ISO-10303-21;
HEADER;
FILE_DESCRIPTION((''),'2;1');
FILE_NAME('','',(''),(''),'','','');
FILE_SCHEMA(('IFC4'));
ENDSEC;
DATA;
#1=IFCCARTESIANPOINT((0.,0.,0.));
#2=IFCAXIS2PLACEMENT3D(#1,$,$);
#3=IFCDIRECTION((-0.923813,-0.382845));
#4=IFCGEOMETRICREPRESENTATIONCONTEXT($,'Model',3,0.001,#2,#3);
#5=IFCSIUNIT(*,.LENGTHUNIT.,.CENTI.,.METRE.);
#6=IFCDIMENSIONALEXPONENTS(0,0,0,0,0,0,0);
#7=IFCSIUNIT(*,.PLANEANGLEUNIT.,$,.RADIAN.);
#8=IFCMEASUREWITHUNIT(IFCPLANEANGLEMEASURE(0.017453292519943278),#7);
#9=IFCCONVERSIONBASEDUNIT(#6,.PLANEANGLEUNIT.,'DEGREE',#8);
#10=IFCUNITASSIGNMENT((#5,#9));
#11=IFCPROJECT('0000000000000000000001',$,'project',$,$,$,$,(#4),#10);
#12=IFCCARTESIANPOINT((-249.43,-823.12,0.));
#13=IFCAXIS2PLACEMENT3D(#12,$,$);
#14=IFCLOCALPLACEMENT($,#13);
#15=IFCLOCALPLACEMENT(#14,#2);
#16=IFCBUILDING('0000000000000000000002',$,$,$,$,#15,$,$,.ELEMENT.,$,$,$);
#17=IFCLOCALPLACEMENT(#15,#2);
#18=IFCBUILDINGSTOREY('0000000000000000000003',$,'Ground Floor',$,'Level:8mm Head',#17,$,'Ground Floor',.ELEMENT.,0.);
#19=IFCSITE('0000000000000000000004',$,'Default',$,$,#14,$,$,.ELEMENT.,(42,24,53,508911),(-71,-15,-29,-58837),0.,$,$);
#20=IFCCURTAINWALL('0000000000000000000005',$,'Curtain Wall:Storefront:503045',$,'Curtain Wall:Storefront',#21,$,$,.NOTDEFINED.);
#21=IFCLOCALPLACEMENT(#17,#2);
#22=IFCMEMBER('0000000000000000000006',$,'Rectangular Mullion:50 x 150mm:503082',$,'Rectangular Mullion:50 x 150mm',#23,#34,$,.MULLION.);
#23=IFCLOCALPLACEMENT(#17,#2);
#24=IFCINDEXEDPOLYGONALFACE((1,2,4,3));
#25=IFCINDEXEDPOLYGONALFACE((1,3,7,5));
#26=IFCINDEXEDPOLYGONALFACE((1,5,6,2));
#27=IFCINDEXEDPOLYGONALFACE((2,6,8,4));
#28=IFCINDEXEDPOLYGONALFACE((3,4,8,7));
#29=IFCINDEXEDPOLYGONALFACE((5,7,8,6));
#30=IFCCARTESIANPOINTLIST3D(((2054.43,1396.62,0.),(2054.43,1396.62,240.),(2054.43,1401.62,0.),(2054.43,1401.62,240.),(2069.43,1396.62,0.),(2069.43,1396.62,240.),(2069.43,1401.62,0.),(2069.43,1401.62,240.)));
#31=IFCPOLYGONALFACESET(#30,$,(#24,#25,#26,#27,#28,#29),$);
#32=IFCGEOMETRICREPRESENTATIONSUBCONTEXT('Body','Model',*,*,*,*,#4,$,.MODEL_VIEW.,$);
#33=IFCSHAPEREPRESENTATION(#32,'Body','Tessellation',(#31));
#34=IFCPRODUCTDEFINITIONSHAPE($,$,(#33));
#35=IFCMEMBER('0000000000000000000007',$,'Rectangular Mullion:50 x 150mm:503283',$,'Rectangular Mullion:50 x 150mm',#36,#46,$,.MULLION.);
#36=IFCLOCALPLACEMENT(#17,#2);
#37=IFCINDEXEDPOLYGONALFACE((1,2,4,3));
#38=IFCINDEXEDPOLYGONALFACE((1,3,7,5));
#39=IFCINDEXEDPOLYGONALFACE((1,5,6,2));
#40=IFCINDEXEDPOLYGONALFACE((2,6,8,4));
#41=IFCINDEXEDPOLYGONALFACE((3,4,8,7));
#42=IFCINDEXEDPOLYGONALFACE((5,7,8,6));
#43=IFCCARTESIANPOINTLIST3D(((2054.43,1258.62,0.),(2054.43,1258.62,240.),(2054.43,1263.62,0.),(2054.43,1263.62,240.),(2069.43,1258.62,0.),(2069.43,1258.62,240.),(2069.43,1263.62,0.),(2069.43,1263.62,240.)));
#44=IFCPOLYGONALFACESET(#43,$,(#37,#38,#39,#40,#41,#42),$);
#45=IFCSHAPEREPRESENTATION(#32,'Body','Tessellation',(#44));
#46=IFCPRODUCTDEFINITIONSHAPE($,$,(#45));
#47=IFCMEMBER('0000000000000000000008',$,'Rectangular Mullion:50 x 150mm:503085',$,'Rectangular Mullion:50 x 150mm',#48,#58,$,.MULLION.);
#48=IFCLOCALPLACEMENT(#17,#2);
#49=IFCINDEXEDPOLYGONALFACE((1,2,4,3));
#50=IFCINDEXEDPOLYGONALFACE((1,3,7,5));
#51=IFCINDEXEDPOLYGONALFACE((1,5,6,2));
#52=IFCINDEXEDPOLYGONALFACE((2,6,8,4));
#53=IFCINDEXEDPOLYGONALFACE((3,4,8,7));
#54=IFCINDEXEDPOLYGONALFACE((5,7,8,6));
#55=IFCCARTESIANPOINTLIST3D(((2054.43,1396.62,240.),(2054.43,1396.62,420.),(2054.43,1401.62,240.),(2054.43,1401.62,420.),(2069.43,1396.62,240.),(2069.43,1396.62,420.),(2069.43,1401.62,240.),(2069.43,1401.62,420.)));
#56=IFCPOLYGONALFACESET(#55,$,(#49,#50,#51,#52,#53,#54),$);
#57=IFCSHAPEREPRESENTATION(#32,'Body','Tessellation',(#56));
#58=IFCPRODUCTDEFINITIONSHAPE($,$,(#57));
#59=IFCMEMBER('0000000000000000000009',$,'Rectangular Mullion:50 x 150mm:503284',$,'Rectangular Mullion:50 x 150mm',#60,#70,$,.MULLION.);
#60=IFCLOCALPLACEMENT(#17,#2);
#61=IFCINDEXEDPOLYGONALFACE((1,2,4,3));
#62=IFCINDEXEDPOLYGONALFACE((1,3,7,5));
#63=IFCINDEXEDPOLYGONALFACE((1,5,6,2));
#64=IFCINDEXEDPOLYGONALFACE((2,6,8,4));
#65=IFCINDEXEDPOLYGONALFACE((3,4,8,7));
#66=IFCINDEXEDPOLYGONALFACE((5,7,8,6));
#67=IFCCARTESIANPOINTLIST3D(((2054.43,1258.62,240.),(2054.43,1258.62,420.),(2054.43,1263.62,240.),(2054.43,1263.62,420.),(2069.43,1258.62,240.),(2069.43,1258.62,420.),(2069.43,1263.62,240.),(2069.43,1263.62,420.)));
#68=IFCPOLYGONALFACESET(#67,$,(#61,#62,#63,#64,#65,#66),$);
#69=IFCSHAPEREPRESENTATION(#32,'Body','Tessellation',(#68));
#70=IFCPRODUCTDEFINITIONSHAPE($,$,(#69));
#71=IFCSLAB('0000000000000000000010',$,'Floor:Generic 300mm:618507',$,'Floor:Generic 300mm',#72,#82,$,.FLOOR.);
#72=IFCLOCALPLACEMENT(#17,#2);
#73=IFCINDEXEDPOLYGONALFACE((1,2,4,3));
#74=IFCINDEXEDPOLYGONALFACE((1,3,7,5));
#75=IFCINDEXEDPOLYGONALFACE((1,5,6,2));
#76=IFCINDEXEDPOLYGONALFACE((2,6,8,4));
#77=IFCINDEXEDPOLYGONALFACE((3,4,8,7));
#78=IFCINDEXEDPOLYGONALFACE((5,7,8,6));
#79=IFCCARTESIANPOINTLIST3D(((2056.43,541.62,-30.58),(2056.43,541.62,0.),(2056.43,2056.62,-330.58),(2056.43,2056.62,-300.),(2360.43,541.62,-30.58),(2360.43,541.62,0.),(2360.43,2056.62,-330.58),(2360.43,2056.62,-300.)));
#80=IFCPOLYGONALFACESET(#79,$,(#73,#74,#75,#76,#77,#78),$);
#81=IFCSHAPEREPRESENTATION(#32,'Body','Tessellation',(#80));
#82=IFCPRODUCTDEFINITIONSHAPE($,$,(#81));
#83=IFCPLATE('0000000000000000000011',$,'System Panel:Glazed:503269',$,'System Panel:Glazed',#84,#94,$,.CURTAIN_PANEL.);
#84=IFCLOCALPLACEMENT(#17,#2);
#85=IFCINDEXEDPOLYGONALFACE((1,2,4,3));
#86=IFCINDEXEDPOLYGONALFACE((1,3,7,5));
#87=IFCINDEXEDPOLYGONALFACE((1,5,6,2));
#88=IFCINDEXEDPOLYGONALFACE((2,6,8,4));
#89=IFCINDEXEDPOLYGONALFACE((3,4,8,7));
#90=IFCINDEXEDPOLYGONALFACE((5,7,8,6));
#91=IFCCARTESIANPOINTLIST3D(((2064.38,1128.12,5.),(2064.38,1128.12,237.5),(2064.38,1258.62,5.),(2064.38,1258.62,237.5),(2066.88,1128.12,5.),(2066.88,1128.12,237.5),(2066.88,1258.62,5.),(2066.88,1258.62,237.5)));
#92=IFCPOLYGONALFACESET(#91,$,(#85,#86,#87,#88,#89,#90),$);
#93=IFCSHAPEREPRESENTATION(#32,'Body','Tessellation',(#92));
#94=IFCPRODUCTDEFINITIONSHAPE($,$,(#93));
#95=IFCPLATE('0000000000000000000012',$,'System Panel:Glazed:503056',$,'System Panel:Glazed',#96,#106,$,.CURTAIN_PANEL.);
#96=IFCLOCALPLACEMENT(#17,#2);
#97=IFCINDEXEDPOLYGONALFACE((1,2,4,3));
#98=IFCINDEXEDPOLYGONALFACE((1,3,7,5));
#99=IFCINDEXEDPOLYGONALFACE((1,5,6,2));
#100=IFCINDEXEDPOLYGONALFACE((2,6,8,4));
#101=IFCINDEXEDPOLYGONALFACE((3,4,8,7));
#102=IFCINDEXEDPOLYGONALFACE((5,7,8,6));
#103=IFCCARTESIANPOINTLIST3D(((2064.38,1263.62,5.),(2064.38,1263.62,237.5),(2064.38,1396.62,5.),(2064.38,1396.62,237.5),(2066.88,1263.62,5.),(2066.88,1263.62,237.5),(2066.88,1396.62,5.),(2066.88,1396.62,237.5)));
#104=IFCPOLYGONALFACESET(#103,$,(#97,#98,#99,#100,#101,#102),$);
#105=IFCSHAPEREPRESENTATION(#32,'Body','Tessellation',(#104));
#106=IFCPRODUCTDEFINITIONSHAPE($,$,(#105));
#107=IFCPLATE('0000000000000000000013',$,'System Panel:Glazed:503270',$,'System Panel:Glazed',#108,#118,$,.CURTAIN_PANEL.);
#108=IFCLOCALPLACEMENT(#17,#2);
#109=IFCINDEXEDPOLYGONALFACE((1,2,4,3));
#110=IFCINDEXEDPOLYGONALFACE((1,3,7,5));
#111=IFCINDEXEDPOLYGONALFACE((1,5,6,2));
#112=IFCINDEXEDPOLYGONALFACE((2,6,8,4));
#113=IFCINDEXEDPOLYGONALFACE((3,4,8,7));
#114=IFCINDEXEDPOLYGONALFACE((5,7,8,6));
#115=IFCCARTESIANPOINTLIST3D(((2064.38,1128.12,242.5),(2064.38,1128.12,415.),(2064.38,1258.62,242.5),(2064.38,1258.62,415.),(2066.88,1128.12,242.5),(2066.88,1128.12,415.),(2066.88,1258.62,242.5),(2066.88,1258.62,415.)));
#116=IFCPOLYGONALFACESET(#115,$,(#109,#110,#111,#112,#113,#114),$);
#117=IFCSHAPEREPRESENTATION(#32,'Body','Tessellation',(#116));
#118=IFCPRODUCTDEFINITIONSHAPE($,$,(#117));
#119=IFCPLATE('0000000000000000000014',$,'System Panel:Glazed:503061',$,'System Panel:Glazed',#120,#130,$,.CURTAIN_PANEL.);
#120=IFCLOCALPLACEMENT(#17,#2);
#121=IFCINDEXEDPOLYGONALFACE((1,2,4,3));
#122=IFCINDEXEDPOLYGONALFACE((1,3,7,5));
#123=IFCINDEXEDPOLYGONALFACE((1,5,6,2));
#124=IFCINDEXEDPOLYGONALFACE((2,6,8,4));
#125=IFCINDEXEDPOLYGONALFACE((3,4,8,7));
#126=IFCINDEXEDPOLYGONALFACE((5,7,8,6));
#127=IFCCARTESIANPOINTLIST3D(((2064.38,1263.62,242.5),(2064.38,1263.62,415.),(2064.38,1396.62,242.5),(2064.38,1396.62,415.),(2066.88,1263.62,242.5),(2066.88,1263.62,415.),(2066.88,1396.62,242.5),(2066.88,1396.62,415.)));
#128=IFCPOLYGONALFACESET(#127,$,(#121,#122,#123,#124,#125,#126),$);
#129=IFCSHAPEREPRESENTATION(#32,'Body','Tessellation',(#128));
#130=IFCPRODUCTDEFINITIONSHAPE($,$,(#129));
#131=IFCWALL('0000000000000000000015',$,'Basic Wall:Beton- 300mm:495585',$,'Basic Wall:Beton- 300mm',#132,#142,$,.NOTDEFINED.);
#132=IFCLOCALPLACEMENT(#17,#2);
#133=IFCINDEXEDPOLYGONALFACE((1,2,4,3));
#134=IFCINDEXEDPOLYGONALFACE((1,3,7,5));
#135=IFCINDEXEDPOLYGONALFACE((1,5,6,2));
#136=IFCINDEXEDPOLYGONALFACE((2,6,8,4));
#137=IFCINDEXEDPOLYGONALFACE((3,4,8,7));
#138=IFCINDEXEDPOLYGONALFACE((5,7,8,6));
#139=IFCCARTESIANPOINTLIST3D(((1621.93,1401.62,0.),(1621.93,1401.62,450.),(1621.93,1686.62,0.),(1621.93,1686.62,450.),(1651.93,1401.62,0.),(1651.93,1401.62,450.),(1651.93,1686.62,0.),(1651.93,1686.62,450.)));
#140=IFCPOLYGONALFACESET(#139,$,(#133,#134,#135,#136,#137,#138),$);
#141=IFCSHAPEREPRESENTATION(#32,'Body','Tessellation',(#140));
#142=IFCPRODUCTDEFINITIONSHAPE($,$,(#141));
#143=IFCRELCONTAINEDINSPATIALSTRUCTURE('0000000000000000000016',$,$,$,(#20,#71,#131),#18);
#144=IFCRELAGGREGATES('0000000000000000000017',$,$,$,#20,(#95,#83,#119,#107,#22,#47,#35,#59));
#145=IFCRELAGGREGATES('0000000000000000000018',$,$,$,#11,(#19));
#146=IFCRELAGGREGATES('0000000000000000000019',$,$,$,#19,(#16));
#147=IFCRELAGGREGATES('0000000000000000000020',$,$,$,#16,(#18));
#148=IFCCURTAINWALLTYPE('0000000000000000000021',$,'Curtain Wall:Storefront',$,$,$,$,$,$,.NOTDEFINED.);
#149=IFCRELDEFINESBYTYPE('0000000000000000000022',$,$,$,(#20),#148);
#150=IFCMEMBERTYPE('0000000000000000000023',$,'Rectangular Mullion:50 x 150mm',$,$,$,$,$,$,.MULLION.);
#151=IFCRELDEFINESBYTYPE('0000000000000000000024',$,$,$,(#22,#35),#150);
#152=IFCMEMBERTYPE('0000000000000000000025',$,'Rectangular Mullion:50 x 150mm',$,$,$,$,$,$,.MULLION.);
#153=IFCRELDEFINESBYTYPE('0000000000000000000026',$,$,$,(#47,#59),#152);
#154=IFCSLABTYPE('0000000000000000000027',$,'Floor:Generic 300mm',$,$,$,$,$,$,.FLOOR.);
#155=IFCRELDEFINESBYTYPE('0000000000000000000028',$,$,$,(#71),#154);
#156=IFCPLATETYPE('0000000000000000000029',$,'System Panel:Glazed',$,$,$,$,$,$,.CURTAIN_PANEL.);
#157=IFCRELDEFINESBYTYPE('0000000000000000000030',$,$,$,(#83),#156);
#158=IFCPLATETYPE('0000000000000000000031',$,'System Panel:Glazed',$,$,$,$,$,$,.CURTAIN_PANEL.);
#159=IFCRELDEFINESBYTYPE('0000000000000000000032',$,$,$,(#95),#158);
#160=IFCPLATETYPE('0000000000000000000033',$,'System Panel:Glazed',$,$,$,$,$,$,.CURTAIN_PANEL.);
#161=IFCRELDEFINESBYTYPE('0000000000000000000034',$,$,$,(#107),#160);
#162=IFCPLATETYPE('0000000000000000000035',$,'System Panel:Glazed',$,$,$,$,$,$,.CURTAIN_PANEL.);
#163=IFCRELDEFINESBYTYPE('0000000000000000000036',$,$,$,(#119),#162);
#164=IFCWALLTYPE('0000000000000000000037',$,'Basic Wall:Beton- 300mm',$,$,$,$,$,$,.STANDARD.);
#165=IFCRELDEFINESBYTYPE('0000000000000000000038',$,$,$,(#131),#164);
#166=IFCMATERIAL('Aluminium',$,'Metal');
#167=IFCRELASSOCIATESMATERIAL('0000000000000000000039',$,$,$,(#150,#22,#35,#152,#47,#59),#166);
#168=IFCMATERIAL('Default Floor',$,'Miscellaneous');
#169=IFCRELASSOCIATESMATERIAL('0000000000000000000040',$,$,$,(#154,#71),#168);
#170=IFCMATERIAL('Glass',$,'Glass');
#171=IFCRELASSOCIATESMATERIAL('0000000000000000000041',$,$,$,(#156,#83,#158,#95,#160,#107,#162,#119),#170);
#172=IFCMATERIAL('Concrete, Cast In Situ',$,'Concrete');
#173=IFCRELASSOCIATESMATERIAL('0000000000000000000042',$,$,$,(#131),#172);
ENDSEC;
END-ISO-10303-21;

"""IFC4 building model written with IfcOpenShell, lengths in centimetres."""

from ifc_helpers import new_model, entity, si_unit, converted_unit, direction, frame, frame_2d, origin, place, context, subcontext, project, spatial, indexed_curve, rectangle, outline, extrude, source, transform, mapped, material, type_object, type_shapes, element, aggregate, save


model = new_model("IFC4")

# Units and contexts
model_context = context("Model", 3, precision=0.001, world=origin(), true_north=direction((-0.923813, -0.382845)))
body_context = subcontext(model_context, "Body", "Model", "MODEL_VIEW")
ifc_project = project(units=[si_unit("LENGTHUNIT", "METRE", prefix="CENTI"), converted_unit("PLANEANGLEUNIT", "DEGREE", entity("IfcPlaneAngleMeasure", 0.017453292519943278), si_unit("PLANEANGLEUNIT", "RADIAN"), dimensions=[0, 0, 0, 0, 0, 0, 0])], contexts=[model_context])

# Site, building, storey
site_placement = place(None, frame((-249.43, -823.12, 0.0)))
site = spatial("IfcSite", under=ifc_project, at=site_placement, Name="Default", CompositionType="ELEMENT", RefLatitude=(42, 24, 53, 508911), RefLongitude=(-71, -15, -29, -58837), RefElevation=0.0)
building_placement = place(site_placement, origin())
building = spatial("IfcBuilding", under=site, at=building_placement, CompositionType="ELEMENT")
storey_placement = place(building_placement, origin())
storey = spatial("IfcBuildingStorey", under=building, at=storey_placement, Name="Ground Floor", ObjectType="Level:8mm Head", LongName="Ground Floor", CompositionType="ELEMENT", Elevation=0.0)

# Curtain wall, members
curtain_wall_type = type_object("IfcCurtainWallType", Name="Curtain Wall:Storefront", PredefinedType="NOTDEFINED")
curtain_wall_placement = place(storey_placement, origin())
curtain_wall = element("IfcCurtainWall", 1, at=curtain_wall_placement, inside=storey, type_object=curtain_wall_type, Name="Curtain Wall:Storefront:503045", ObjectType="Curtain Wall:Storefront", PredefinedType="NOTDEFINED")
ifc_material_1 = material(Name="Aluminium", Category="Metal")
member_type_1 = type_object("IfcMemberType", Name="Rectangular Mullion:50 x 150mm", PredefinedType="MULLION", material=ifc_material_1)
shared_shape_1 = source(origin(), body_context, "Body", "SweptSolid", [
    extrude(outline(indexed_curve([(-2.5, -7.5), (2.5, -7.5), (2.5, 7.5), (-2.5, 7.5), (-2.5, -7.5)], self_intersect=False)), frame((0.0, 0.0, -240.0), z_axis=(0.0, 0.0, 1.0), x_axis=(-1.0, 0.0, 0.0)), (0.0, 0.0, 1.0), 240.0),
])
type_shapes(member_type_1, [shared_shape_1])
member_1_placement = place(curtain_wall_placement, frame((2061.93, 1399.12, 0.0), z_axis=(0.0, 0.0, -1.0), x_axis=(0.0, -1.0, 0.0)))
member_1 = element("IfcMember", 2, at=member_1_placement, type_object=member_type_1, material=ifc_material_1, Name="Rectangular Mullion:50 x 150mm:503082", ObjectType="Rectangular Mullion:50 x 150mm", PredefinedType="MULLION", context=body_context, shape_type="MappedRepresentation", body=[
    mapped(shared_shape_1, transform((0.0, 0.0, 0.0), scale=1.0)),
])
member_2_placement = place(curtain_wall_placement, frame((2061.93, 1261.12, 0.0), z_axis=(0.0, 0.0, -1.0), x_axis=(0.0, -1.0, 0.0)))
member_2 = element("IfcMember", 3, at=member_2_placement, type_object=member_type_1, material=ifc_material_1, Name="Rectangular Mullion:50 x 150mm:503283", ObjectType="Rectangular Mullion:50 x 150mm", PredefinedType="MULLION", context=body_context, shape_type="MappedRepresentation", body=[
    mapped(shared_shape_1, transform((0.0, 0.0, 0.0), scale=1.0)),
])
member_type_2 = type_object("IfcMemberType", Name="Rectangular Mullion:50 x 150mm", PredefinedType="MULLION", material=ifc_material_1)
shared_shape_2 = source(origin(), body_context, "Body", "SweptSolid", [
    extrude(outline(indexed_curve([(-2.5, -7.5), (2.5, -7.5), (2.5, 7.5), (-2.5, 7.5), (-2.5, -7.5)], self_intersect=False)), frame((0.0, 0.0, -180.0), z_axis=(0.0, 0.0, 1.0), x_axis=(-1.0, 0.0, 0.0)), (0.0, 0.0, 1.0), 180.0),
])
type_shapes(member_type_2, [shared_shape_2])
member_3_placement = place(curtain_wall_placement, frame((2061.93, 1399.12, 240.0), z_axis=(0.0, 0.0, -1.0), x_axis=(0.0, -1.0, 0.0)))
member_3 = element("IfcMember", 4, at=member_3_placement, type_object=member_type_2, material=ifc_material_1, Name="Rectangular Mullion:50 x 150mm:503085", ObjectType="Rectangular Mullion:50 x 150mm", PredefinedType="MULLION", context=body_context, shape_type="MappedRepresentation", body=[
    mapped(shared_shape_2, transform((0.0, 0.0, 0.0), scale=1.0)),
])
member_4_placement = place(curtain_wall_placement, frame((2061.93, 1261.12, 240.0), z_axis=(0.0, 0.0, -1.0), x_axis=(0.0, -1.0, 0.0)))
member_4 = element("IfcMember", 5, at=member_4_placement, type_object=member_type_2, material=ifc_material_1, Name="Rectangular Mullion:50 x 150mm:503284", ObjectType="Rectangular Mullion:50 x 150mm", PredefinedType="MULLION", context=body_context, shape_type="MappedRepresentation", body=[
    mapped(shared_shape_2, transform((0.0, 0.0, 0.0), scale=1.0)),
])

# Slab
ifc_material_2 = material(Name="Default Floor", Category="Miscellaneous")
slab_type = type_object("IfcSlabType", Name="Floor:Generic 300mm", PredefinedType="FLOOR", material=ifc_material_2)
slab_placement = place(storey_placement, frame((2056.43, 541.62, -330.58)))
element("IfcSlab", 6, at=slab_placement, inside=storey, type_object=slab_type, material=ifc_material_2, Name="Floor:Generic 300mm:618507", ObjectType="Floor:Generic 300mm", PredefinedType="FLOOR", context=body_context, shape_type="SweptSolid", body=[
    extrude(rectangle(XDim=1544.42, YDim=304.0, at=frame_2d((-7.0, -772.21), x_axis=(0.0, 1.0))), frame((159.0, 1515.0, 30.58), z_axis=(0.0, 0.194248, 0.980952), x_axis=(1.0, 0.0, 0.0)), (0.0, 0.194248, -0.980952), 30.58),
])

# Plates
ifc_material_3 = material(Name="Glass", Category="Glass")
plate_type_1 = type_object("IfcPlateType", Name="System Panel:Glazed", PredefinedType="CURTAIN_PANEL", material=ifc_material_3)
shared_shape_3 = source(origin(), body_context, "Body", "SweptSolid", [
    extrude(outline(indexed_curve([(-1.25, -65.25), (1.25, -65.25), (1.25, 65.25), (-1.25, 65.25), (-1.25, -65.25)], self_intersect=False)), frame((65.25, 1.25, 0.0), z_axis=(0.0, 0.0, 1.0), x_axis=(0.0, 1.0, 0.0)), (0.0, 0.0, 1.0), 232.5),
])
type_shapes(plate_type_1, [shared_shape_3])
plate_1_placement = place(curtain_wall_placement, frame((2064.38, 1258.62, 5.0), z_axis=(0.0, 0.0, 1.0), x_axis=(0.0, -1.0, 0.0)))
plate_1 = element("IfcPlate", 7, at=plate_1_placement, type_object=plate_type_1, material=ifc_material_3, Name="System Panel:Glazed:503269", ObjectType="System Panel:Glazed", PredefinedType="CURTAIN_PANEL", context=body_context, shape_type="MappedRepresentation", body=[
    mapped(shared_shape_3, transform((0.0, 0.0, 0.0), scale=1.0)),
])
plate_type_2 = type_object("IfcPlateType", Name="System Panel:Glazed", PredefinedType="CURTAIN_PANEL", material=ifc_material_3)
shared_shape_4 = source(origin(), body_context, "Body", "SweptSolid", [
    extrude(outline(indexed_curve([(-1.25, -66.5), (1.25, -66.5), (1.25, 66.5), (-1.25, 66.5), (-1.25, -66.5)], self_intersect=False)), frame((66.5, 1.25, 0.0), z_axis=(0.0, 0.0, 1.0), x_axis=(0.0, 1.0, 0.0)), (0.0, 0.0, 1.0), 232.5),
])
type_shapes(plate_type_2, [shared_shape_4])
plate_2_placement = place(curtain_wall_placement, frame((2064.38, 1396.62, 5.0), z_axis=(0.0, 0.0, 1.0), x_axis=(0.0, -1.0, 0.0)))
plate_2 = element("IfcPlate", 8, at=plate_2_placement, type_object=plate_type_2, material=ifc_material_3, Name="System Panel:Glazed:503056", ObjectType="System Panel:Glazed", PredefinedType="CURTAIN_PANEL", context=body_context, shape_type="MappedRepresentation", body=[
    mapped(shared_shape_4, transform((0.0, 0.0, 0.0), scale=1.0)),
])
plate_type_3 = type_object("IfcPlateType", Name="System Panel:Glazed", PredefinedType="CURTAIN_PANEL", material=ifc_material_3)
shared_shape_5 = source(origin(), body_context, "Body", "SweptSolid", [
    extrude(outline(indexed_curve([(-1.25, -65.25), (1.25, -65.25), (1.25, 65.25), (-1.25, 65.25), (-1.25, -65.25)], self_intersect=False)), frame((65.25, 1.25, 0.0), z_axis=(0.0, 0.0, 1.0), x_axis=(0.0, 1.0, 0.0)), (0.0, 0.0, 1.0), 172.5),
])
type_shapes(plate_type_3, [shared_shape_5])
plate_3_placement = place(curtain_wall_placement, frame((2064.38, 1258.62, 242.5), z_axis=(0.0, 0.0, 1.0), x_axis=(0.0, -1.0, 0.0)))
plate_3 = element("IfcPlate", 9, at=plate_3_placement, type_object=plate_type_3, material=ifc_material_3, Name="System Panel:Glazed:503270", ObjectType="System Panel:Glazed", PredefinedType="CURTAIN_PANEL", context=body_context, shape_type="MappedRepresentation", body=[
    mapped(shared_shape_5, transform((0.0, 0.0, 0.0), scale=1.0)),
])
plate_type_4 = type_object("IfcPlateType", Name="System Panel:Glazed", PredefinedType="CURTAIN_PANEL", material=ifc_material_3)
shared_shape_6 = source(origin(), body_context, "Body", "SweptSolid", [
    extrude(outline(indexed_curve([(-1.25, -66.5), (1.25, -66.5), (1.25, 66.5), (-1.25, 66.5), (-1.25, -66.5)], self_intersect=False)), frame((66.5, 1.25, 0.0), z_axis=(0.0, 0.0, 1.0), x_axis=(0.0, 1.0, 0.0)), (0.0, 0.0, 1.0), 172.5),
])
type_shapes(plate_type_4, [shared_shape_6])
plate_4_placement = place(curtain_wall_placement, frame((2064.38, 1396.62, 242.5), z_axis=(0.0, 0.0, 1.0), x_axis=(0.0, -1.0, 0.0)))
plate_4 = element("IfcPlate", 10, at=plate_4_placement, type_object=plate_type_4, material=ifc_material_3, Name="System Panel:Glazed:503061", ObjectType="System Panel:Glazed", PredefinedType="CURTAIN_PANEL", context=body_context, shape_type="MappedRepresentation", body=[
    mapped(shared_shape_6, transform((0.0, 0.0, 0.0), scale=1.0)),
])
aggregate(curtain_wall, [plate_2, plate_1, plate_4, plate_3, member_1, member_3, member_2, member_4])

# Wall
ifc_material_4 = material(Name="Concrete, Cast In Situ", Category="Concrete")
wall_type_1 = type_object("IfcWallType", Name="Basic Wall:Beton- 300mm", PredefinedType="STANDARD")
wall_1_placement = place(storey_placement, frame((1636.93, 1401.62, 0.0), z_axis=(0.0, 0.0, 1.0), x_axis=(0.0, 1.0, 0.0)))
element("IfcWall", 11, at=wall_1_placement, inside=storey, type_object=wall_type_1, material=ifc_material_4, Name="Basic Wall:Beton- 300mm:495585", ObjectType="Basic Wall:Beton- 300mm", PredefinedType="NOTDEFINED", context=body_context, shape_type="SweptSolid", body=[
    extrude(outline(indexed_curve([(285.0, 15.0), (0.0, 15.0), (0.0, -15.0), (285.0, -15.0), (285.0, 15.0)], self_intersect=False)), origin(), (0.0, 0.0, 1.0), 450.0),
])

save(model, "model.ifc")
